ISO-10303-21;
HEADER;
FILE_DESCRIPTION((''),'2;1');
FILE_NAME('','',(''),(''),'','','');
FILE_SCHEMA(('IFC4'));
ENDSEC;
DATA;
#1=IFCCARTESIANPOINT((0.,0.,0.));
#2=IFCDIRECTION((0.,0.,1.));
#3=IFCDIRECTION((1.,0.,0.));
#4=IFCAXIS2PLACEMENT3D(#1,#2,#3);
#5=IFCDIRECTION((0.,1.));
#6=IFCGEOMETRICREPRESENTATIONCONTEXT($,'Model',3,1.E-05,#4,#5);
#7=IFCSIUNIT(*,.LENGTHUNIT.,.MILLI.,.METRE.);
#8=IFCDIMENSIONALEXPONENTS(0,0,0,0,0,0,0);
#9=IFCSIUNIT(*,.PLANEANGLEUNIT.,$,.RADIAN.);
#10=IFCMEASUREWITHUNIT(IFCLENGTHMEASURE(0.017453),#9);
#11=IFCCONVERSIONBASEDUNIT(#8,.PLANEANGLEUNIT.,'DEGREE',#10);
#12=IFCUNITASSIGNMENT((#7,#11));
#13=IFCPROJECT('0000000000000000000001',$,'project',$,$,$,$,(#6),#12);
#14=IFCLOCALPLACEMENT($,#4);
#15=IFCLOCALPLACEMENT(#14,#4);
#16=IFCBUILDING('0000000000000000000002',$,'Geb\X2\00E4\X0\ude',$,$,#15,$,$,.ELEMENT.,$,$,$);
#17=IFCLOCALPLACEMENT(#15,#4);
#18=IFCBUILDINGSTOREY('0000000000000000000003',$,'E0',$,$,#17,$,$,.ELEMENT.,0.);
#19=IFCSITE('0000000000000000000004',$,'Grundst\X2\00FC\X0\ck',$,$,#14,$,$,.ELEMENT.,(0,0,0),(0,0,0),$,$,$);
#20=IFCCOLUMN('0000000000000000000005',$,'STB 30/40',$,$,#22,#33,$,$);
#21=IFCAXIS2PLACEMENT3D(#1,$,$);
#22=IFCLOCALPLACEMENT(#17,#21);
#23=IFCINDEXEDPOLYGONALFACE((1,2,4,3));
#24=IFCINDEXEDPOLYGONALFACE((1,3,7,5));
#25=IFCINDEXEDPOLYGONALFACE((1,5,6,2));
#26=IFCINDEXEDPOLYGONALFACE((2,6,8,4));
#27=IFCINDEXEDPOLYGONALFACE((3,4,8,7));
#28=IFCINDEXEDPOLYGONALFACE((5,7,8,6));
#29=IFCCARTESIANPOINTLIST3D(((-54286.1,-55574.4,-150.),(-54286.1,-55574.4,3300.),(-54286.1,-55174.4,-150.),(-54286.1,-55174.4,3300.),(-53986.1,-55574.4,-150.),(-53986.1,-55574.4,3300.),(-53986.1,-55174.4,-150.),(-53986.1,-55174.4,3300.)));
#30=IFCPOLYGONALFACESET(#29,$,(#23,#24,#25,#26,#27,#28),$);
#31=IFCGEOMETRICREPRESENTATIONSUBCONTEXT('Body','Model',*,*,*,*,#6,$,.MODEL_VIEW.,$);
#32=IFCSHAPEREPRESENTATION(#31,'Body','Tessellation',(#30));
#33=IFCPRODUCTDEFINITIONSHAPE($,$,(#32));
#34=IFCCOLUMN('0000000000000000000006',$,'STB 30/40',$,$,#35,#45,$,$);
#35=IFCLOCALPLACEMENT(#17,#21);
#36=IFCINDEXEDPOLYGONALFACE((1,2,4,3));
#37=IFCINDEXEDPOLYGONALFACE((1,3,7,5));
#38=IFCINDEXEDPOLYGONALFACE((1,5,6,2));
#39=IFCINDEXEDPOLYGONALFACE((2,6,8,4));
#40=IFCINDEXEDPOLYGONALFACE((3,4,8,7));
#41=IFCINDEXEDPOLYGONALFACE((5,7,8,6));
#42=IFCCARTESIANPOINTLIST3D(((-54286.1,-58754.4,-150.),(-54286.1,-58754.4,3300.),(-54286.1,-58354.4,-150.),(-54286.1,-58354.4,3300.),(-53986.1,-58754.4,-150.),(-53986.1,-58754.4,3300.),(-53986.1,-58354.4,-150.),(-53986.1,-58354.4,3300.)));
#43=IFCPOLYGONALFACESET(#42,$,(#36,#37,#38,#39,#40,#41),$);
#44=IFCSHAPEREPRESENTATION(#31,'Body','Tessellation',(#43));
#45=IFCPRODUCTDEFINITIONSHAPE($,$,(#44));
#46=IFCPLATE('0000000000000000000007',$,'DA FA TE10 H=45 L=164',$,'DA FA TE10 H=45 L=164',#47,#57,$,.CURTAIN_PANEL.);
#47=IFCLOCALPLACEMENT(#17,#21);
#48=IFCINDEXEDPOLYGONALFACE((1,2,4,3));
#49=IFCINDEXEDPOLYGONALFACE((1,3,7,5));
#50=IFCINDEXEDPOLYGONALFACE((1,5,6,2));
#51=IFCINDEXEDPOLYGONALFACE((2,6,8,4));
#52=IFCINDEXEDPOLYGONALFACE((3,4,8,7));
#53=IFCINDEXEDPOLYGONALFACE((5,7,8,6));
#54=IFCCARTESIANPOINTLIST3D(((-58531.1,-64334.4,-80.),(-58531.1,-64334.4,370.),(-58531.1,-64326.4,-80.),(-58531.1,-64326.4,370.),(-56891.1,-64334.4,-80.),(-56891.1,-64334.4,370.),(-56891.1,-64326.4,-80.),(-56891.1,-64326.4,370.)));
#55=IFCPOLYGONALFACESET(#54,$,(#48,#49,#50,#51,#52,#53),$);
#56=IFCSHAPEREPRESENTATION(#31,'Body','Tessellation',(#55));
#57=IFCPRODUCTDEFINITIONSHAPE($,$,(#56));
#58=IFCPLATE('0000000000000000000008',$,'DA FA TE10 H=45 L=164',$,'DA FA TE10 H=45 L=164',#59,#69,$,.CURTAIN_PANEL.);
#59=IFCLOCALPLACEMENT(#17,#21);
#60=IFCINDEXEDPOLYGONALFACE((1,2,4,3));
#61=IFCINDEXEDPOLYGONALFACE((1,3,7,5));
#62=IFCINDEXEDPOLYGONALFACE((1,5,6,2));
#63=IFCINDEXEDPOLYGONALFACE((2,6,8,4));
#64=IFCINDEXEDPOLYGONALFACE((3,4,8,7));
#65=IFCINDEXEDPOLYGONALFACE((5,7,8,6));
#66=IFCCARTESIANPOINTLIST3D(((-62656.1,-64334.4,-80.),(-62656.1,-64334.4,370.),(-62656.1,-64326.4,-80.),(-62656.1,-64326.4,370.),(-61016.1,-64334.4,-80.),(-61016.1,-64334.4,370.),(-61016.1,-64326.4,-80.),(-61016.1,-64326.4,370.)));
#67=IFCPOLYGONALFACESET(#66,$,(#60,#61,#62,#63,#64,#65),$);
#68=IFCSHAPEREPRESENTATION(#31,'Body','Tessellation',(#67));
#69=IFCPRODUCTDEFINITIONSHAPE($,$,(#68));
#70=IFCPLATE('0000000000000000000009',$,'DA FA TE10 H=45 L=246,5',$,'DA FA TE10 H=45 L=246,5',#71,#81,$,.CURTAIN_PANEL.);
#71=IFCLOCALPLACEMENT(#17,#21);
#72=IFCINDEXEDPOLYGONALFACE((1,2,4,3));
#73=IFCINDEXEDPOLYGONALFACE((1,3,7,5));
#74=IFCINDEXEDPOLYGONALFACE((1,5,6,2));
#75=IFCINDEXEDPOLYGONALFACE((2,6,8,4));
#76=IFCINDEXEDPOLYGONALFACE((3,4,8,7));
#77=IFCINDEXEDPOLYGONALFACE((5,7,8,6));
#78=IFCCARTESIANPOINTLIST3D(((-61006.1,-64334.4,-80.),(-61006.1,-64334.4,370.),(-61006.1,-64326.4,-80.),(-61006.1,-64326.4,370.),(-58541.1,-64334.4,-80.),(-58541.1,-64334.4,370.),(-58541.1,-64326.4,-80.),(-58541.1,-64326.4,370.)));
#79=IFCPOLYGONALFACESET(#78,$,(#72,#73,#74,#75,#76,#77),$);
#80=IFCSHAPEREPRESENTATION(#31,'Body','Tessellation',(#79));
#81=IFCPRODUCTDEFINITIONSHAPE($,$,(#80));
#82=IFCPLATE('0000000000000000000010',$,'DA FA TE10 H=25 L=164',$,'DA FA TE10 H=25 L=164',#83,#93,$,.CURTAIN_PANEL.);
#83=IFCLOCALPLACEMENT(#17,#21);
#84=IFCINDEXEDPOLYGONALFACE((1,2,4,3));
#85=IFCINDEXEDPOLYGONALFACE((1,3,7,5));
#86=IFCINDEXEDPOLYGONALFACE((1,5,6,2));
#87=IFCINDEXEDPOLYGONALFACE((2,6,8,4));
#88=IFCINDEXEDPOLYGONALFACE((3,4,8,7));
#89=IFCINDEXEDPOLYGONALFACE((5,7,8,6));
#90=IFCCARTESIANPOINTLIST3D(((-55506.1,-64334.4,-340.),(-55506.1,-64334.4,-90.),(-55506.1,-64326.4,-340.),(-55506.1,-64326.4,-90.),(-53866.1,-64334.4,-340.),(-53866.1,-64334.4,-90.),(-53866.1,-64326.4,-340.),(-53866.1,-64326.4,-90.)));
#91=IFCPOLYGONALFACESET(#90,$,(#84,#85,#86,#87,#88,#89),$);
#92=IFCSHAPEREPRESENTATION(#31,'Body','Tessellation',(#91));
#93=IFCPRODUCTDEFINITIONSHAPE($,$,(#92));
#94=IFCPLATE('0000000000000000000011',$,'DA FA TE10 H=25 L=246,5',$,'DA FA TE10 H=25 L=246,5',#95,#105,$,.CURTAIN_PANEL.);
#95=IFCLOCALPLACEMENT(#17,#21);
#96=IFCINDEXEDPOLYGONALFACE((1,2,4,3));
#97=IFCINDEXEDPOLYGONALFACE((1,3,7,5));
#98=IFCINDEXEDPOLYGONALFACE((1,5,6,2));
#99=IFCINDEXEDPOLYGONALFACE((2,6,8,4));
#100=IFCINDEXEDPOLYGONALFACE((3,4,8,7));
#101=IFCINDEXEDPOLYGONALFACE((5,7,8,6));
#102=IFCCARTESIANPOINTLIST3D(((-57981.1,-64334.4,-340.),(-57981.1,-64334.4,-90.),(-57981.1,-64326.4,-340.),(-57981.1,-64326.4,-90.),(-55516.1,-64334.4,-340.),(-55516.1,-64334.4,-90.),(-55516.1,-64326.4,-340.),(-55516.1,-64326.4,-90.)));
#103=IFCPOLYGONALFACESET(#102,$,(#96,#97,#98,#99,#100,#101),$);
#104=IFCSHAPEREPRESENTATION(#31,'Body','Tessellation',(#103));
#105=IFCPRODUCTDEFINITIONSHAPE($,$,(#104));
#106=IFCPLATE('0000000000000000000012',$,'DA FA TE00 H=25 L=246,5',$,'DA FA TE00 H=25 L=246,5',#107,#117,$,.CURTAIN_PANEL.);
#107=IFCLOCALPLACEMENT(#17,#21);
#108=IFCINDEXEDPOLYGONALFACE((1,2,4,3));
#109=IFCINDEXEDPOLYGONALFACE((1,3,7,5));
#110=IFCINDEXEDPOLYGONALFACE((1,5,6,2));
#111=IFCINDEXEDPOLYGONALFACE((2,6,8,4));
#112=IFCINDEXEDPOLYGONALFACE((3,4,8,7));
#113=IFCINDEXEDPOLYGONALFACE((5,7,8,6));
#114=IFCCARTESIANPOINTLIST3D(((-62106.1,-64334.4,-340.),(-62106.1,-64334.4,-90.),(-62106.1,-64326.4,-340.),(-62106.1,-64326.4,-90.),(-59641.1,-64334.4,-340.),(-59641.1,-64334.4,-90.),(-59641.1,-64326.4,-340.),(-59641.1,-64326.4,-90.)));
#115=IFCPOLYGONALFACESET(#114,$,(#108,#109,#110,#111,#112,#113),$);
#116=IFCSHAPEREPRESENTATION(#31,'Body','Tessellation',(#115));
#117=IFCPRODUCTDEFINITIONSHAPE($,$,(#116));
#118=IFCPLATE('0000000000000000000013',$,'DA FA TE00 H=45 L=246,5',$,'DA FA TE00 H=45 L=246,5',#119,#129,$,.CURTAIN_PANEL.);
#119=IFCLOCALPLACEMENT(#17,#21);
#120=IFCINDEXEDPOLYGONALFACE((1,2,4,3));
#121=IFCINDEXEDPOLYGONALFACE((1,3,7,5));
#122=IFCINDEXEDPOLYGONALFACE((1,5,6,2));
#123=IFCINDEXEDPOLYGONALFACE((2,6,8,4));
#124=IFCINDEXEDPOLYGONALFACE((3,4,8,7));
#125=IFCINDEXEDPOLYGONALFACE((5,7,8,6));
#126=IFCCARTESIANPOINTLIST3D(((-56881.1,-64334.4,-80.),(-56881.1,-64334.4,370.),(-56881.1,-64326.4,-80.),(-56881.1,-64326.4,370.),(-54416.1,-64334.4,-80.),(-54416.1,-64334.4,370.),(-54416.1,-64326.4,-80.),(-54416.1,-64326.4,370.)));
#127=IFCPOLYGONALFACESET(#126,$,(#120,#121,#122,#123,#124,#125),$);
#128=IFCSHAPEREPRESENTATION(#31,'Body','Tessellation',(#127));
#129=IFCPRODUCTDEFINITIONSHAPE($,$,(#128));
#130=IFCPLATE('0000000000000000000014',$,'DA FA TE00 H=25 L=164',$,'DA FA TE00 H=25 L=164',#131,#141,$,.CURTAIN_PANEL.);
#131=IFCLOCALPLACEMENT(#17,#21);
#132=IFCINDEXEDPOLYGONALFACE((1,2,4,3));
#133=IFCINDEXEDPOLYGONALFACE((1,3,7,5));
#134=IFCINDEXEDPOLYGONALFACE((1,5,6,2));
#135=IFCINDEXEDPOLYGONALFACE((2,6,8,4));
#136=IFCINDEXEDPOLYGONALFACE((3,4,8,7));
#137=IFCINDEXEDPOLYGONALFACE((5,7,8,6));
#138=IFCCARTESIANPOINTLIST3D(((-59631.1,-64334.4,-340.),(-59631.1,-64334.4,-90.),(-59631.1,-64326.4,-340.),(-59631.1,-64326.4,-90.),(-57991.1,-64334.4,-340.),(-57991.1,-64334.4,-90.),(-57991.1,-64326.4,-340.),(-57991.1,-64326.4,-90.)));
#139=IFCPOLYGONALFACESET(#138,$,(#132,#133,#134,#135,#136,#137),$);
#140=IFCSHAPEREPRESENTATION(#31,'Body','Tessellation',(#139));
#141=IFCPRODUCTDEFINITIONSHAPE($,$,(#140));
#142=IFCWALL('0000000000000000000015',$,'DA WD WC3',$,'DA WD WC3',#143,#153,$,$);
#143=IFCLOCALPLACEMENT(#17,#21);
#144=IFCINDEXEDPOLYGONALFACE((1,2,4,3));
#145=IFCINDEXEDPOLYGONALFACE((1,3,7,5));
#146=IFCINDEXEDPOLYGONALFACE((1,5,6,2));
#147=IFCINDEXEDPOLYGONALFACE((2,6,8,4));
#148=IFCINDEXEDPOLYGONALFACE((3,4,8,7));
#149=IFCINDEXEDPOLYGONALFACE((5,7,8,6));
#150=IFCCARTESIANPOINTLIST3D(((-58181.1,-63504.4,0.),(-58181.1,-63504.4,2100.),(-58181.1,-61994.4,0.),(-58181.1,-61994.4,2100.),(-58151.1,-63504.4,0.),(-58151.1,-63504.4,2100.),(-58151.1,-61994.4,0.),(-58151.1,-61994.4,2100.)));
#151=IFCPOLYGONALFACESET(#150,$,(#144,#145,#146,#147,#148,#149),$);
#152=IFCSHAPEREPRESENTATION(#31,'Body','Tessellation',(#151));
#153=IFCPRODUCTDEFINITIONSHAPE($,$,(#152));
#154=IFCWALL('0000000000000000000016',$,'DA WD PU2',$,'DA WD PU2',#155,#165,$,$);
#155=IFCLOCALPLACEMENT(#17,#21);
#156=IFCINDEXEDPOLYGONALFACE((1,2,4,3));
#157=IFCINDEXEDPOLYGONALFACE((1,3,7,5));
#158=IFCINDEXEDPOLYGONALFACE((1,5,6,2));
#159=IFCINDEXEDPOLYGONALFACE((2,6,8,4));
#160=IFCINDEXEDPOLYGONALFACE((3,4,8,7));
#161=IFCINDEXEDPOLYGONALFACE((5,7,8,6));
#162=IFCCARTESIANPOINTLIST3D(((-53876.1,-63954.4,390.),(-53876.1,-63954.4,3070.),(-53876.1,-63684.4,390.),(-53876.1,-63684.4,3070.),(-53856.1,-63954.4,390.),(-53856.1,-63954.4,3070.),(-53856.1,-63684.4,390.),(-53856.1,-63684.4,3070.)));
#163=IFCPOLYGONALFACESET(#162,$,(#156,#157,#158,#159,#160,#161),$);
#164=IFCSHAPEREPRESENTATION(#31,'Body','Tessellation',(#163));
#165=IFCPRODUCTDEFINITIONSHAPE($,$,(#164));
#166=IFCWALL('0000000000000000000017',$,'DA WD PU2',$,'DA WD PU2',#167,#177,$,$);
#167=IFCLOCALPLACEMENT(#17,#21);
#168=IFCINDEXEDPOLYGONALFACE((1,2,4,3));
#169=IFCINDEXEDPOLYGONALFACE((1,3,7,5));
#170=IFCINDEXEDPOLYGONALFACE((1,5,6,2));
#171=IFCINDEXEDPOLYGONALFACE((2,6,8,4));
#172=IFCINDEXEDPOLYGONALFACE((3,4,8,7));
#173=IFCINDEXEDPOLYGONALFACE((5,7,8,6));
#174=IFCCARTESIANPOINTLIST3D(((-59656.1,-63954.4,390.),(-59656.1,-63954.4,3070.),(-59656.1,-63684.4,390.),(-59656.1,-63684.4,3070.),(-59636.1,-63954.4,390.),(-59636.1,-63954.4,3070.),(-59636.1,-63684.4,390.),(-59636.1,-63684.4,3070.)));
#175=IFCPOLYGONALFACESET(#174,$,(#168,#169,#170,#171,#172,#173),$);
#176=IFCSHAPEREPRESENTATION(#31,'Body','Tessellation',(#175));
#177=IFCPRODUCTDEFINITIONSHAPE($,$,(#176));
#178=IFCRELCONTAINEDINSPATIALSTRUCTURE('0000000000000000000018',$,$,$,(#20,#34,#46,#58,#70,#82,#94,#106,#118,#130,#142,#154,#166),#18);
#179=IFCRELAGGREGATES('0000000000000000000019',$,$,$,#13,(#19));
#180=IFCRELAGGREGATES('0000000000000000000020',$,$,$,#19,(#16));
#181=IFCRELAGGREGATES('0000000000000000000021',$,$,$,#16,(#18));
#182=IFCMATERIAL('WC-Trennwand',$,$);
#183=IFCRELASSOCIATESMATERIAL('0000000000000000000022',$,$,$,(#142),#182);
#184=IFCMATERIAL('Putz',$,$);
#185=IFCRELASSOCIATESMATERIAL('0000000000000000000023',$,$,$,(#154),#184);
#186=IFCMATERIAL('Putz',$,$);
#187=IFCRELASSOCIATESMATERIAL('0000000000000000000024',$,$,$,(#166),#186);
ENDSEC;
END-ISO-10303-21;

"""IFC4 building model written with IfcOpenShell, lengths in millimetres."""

from ifc_helpers import new_model, entity, si_unit, converted_unit, direction, frame, origin_with_axes, place, context, subcontext, project, spatial, line, indexed_curve, outline, extrude, source, transform, mapped, material, element, save


model = new_model("IFC4")

# Units and contexts
model_context = context("Model", 3, precision=1e-05, world=origin_with_axes(), true_north=direction((0.0, 1.0)))
body_context = subcontext(model_context, "Body", "Model", "MODEL_VIEW")
ifc_project = project(units=[si_unit("LENGTHUNIT", "METRE", prefix="MILLI"), converted_unit("PLANEANGLEUNIT", "DEGREE", entity("IfcLengthMeasure", 0.017453), si_unit("PLANEANGLEUNIT", "RADIAN"), dimensions=[0, 0, 0, 0, 0, 0, 0])], contexts=[model_context])

# Site, building, storey
site_placement = place(None, origin_with_axes())
site = spatial("IfcSite", under=ifc_project, at=site_placement, Name="Grundstück", CompositionType="ELEMENT", RefLatitude=(0, 0, 0), RefLongitude=(0, 0, 0))
building_placement = place(site_placement, origin_with_axes())
building = spatial("IfcBuilding", under=site, at=building_placement, Name="Gebäude", CompositionType="ELEMENT")
storey_placement = place(building_placement, origin_with_axes())
storey = spatial("IfcBuildingStorey", under=building, at=storey_placement, Name="E0", CompositionType="ELEMENT", Elevation=0.0)

# Columns
for number, where, z_axis, x_axis, name in (
    (1, (-54136.1, -55374.4, -150.0), (0.0, 0.0, 1.0), (1.0, 0.0, 0.0), "STB 30/40"),
    (2, (-54136.1, -58554.4, -150.0), (0.0, 0.0, 1.0), (1.0, 0.0, 0.0), "STB 30/40"),
):
    element("IfcColumn", number, at=place(storey_placement, frame(where, z_axis=z_axis, x_axis=x_axis)), inside=storey, Name=name, context=body_context, shape_type="SweptSolid", body=[
        extrude(outline(indexed_curve([(-150.0, -200.0), (150.0, -200.0), (150.0, 200.0), (-150.0, 200.0)], segments=[line(1, 2), line(2, 3), line(3, 4), line(4, 1)])), origin_with_axes(), (0.0, 0.0, 1.0), 3450.0),
    ])

# Plates
shared_shape_1 = source(origin_with_axes(), body_context, "Body", "SweptSolid", [
    extrude(outline(indexed_curve([(-820.0, 0.0), (820.0, 0.0), (820.0, 8.0), (-820.0, 8.0)], segments=[line(1, 2), line(2, 3), line(3, 4), line(4, 1)])), frame((0.0, 0.0, 450.0), z_axis=(0.0, 0.0, 1.0), x_axis=(1.0, 0.0, 0.0)), (0.0, 0.0, -1.0), 450.0),
])
for number, where, z_axis, x_axis, name in (
    (3, (-57711.1, -64334.4, -80.0), (0.0, 0.0, 1.0), (1.0, 0.0, 0.0), "DA FA TE10 H=45 L=164"),
    (4, (-61836.1, -64334.4, -80.0), (0.0, 0.0, 1.0), (1.0, 0.0, 0.0), "DA FA TE10 H=45 L=164"),
):
    element("IfcPlate", number, at=place(storey_placement, frame(where, z_axis=z_axis, x_axis=x_axis)), inside=storey, Name=name, ObjectType="DA FA TE10 H=45 L=164", PredefinedType="CURTAIN_PANEL", context=body_context, shape_type="MappedRepresentation", body=[
        mapped(shared_shape_1, transform((0.0, 0.0, 0.0), x_axis=(1.0, 0.0, 0.0), y_axis=(0.0, 1.0, 0.0), z_axis=(0.0, 0.0, 1.0), scale=1.0)),
    ])
shared_shape_2 = source(origin_with_axes(), body_context, "Body", "SweptSolid", [
    extrude(outline(indexed_curve([(-1232.5, 0.0), (1232.5, 0.0), (1232.5, 8.0), (-1232.5, 8.0)], segments=[line(1, 2), line(2, 3), line(3, 4), line(4, 1)])), frame((0.0, 0.0, 450.0), z_axis=(0.0, 0.0, 1.0), x_axis=(1.0, 0.0, 0.0)), (0.0, 0.0, -1.0), 450.0),
])
plate_1_placement = place(storey_placement, frame((-59773.6, -64334.4, -80.0), z_axis=(0.0, 0.0, 1.0), x_axis=(1.0, 0.0, 0.0)))
element("IfcPlate", 5, at=plate_1_placement, inside=storey, Name="DA FA TE10 H=45 L=246,5", ObjectType="DA FA TE10 H=45 L=246,5", PredefinedType="CURTAIN_PANEL", context=body_context, shape_type="MappedRepresentation", body=[
    mapped(shared_shape_2, transform((0.0, 0.0, 0.0), x_axis=(1.0, 0.0, 0.0), y_axis=(0.0, 1.0, 0.0), z_axis=(0.0, 0.0, 1.0), scale=1.0)),
])
shared_shape_3 = source(origin_with_axes(), body_context, "Body", "SweptSolid", [
    extrude(outline(indexed_curve([(-820.0, 0.0), (820.0, 0.0), (820.0, 8.0), (-820.0, 8.0)], segments=[line(1, 2), line(2, 3), line(3, 4), line(4, 1)])), frame((0.0, 0.0, 250.0), z_axis=(0.0, 0.0, 1.0), x_axis=(1.0, 0.0, 0.0)), (0.0, 0.0, -1.0), 250.0),
])
plate_2_placement = place(storey_placement, frame((-54686.1, -64334.4, -340.0), z_axis=(0.0, 0.0, 1.0), x_axis=(1.0, 0.0, 0.0)))
element("IfcPlate", 6, at=plate_2_placement, inside=storey, Name="DA FA TE10 H=25 L=164", ObjectType="DA FA TE10 H=25 L=164", PredefinedType="CURTAIN_PANEL", context=body_context, shape_type="MappedRepresentation", body=[
    mapped(shared_shape_3, transform((0.0, 0.0, 0.0), x_axis=(1.0, 0.0, 0.0), y_axis=(0.0, 1.0, 0.0), z_axis=(0.0, 0.0, 1.0), scale=1.0)),
])
shared_shape_4 = source(origin_with_axes(), body_context, "Body", "SweptSolid", [
    extrude(outline(indexed_curve([(-1232.5, 0.0), (1232.5, 0.0), (1232.5, 8.0), (-1232.5, 8.0)], segments=[line(1, 2), line(2, 3), line(3, 4), line(4, 1)])), frame((0.0, 0.0, 250.0), z_axis=(0.0, 0.0, 1.0), x_axis=(1.0, 0.0, 0.0)), (0.0, 0.0, -1.0), 250.0),
])
plate_3_placement = place(storey_placement, frame((-56748.6, -64334.4, -340.0), z_axis=(0.0, 0.0, 1.0), x_axis=(1.0, 0.0, 0.0)))
element("IfcPlate", 7, at=plate_3_placement, inside=storey, Name="DA FA TE10 H=25 L=246,5", ObjectType="DA FA TE10 H=25 L=246,5", PredefinedType="CURTAIN_PANEL", context=body_context, shape_type="MappedRepresentation", body=[
    mapped(shared_shape_4, transform((0.0, 0.0, 0.0), x_axis=(1.0, 0.0, 0.0), y_axis=(0.0, 1.0, 0.0), z_axis=(0.0, 0.0, 1.0), scale=1.0)),
])
shared_shape_5 = source(origin_with_axes(), body_context, "Body", "SweptSolid", [
    extrude(outline(indexed_curve([(-1232.5, 0.0), (1232.5, 0.0), (1232.5, 8.0), (-1232.5, 8.0)], segments=[line(1, 2), line(2, 3), line(3, 4), line(4, 1)])), frame((0.0, 0.0, 250.0), z_axis=(0.0, 0.0, 1.0), x_axis=(1.0, 0.0, 0.0)), (0.0, 0.0, -1.0), 250.0),
])
plate_4_placement = place(storey_placement, frame((-60873.6, -64334.4, -340.0), z_axis=(0.0, 0.0, 1.0), x_axis=(1.0, 0.0, 0.0)))
element("IfcPlate", 8, at=plate_4_placement, inside=storey, Name="DA FA TE00 H=25 L=246,5", ObjectType="DA FA TE00 H=25 L=246,5", PredefinedType="CURTAIN_PANEL", context=body_context, shape_type="MappedRepresentation", body=[
    mapped(shared_shape_5, transform((0.0, 0.0, 0.0), x_axis=(1.0, 0.0, 0.0), y_axis=(0.0, 1.0, 0.0), z_axis=(0.0, 0.0, 1.0), scale=1.0)),
])
shared_shape_6 = source(origin_with_axes(), body_context, "Body", "SweptSolid", [
    extrude(outline(indexed_curve([(-1232.5, 0.0), (1232.5, 0.0), (1232.5, 8.0), (-1232.5, 8.0)], segments=[line(1, 2), line(2, 3), line(3, 4), line(4, 1)])), frame((0.0, 0.0, 450.0), z_axis=(0.0, 0.0, 1.0), x_axis=(1.0, 0.0, 0.0)), (0.0, 0.0, -1.0), 450.0),
])
plate_5_placement = place(storey_placement, frame((-55648.6, -64334.4, -80.0), z_axis=(0.0, 0.0, 1.0), x_axis=(1.0, 0.0, 0.0)))
element("IfcPlate", 9, at=plate_5_placement, inside=storey, Name="DA FA TE00 H=45 L=246,5", ObjectType="DA FA TE00 H=45 L=246,5", PredefinedType="CURTAIN_PANEL", context=body_context, shape_type="MappedRepresentation", body=[
    mapped(shared_shape_6, transform((0.0, 0.0, 0.0), x_axis=(1.0, 0.0, 0.0), y_axis=(0.0, 1.0, 0.0), z_axis=(0.0, 0.0, 1.0), scale=1.0)),
])
shared_shape_7 = source(origin_with_axes(), body_context, "Body", "SweptSolid", [
    extrude(outline(indexed_curve([(-820.0, 0.0), (820.0, 0.0), (820.0, 8.0), (-820.0, 8.0)], segments=[line(1, 2), line(2, 3), line(3, 4), line(4, 1)])), frame((0.0, 0.0, 250.0), z_axis=(0.0, 0.0, 1.0), x_axis=(1.0, 0.0, 0.0)), (0.0, 0.0, -1.0), 250.0),
])
plate_6_placement = place(storey_placement, frame((-58811.1, -64334.4, -340.0), z_axis=(0.0, 0.0, 1.0), x_axis=(1.0, 0.0, 0.0)))
element("IfcPlate", 10, at=plate_6_placement, inside=storey, Name="DA FA TE00 H=25 L=164", ObjectType="DA FA TE00 H=25 L=164", PredefinedType="CURTAIN_PANEL", context=body_context, shape_type="MappedRepresentation", body=[
    mapped(shared_shape_7, transform((0.0, 0.0, 0.0), x_axis=(1.0, 0.0, 0.0), y_axis=(0.0, 1.0, 0.0), z_axis=(0.0, 0.0, 1.0), scale=1.0)),
])

# Walls
ifc_material_1 = material(Name="WC-Trennwand")
wall_1_placement = place(storey_placement, frame((-58166.1, -63504.4, 0.0), z_axis=(0.0, 0.0, 1.0), x_axis=(0.0, 1.0, 0.0)))
element("IfcWall", 11, at=wall_1_placement, inside=storey, material=ifc_material_1, Name="DA WD WC3", ObjectType="DA WD WC3", context=body_context, shape_type="SweptSolid", body=[
    extrude(outline(indexed_curve([(0.0, -15.0), (0.0, 15.0), (1510.0, 15.0), (1510.0, -15.0)], segments=[line(1, 2), line(2, 3), line(3, 4), line(4, 1)])), origin_with_axes(), (0.0, 0.0, 1.0), 2100.0),
])
ifc_material_2 = material(Name="Putz")
wall_2_placement = place(storey_placement, frame((-53866.1, -63684.4, 390.0), z_axis=(0.0, 0.0, 1.0), x_axis=(0.0, -1.0, 0.0)))
element("IfcWall", 12, at=wall_2_placement, inside=storey, material=ifc_material_2, Name="DA WD PU2", ObjectType="DA WD PU2", context=body_context, shape_type="SweptSolid", body=[
    extrude(outline(indexed_curve([(0.0, -10.0), (0.0, 10.0), (270.0, 10.0), (270.0, -10.0)], segments=[line(1, 2), line(2, 3), line(3, 4), line(4, 1)])), origin_with_axes(), (0.0, 0.0, 1.0), 2680.0),
])
ifc_material_3 = material(Name="Putz")
wall_3_placement = place(storey_placement, frame((-59646.1, -63684.4, 390.0), z_axis=(0.0, 0.0, 1.0), x_axis=(0.0, -1.0, 0.0)))
element("IfcWall", 13, at=wall_3_placement, inside=storey, material=ifc_material_3, Name="DA WD PU2", ObjectType="DA WD PU2", context=body_context, shape_type="SweptSolid", body=[
    extrude(outline(indexed_curve([(0.0, -10.0), (0.0, 10.0), (270.0, 10.0), (270.0, -10.0)], segments=[line(1, 2), line(2, 3), line(3, 4), line(4, 1)])), origin_with_axes(), (0.0, 0.0, 1.0), 2680.0),
])

save(model, "model.ifc")
